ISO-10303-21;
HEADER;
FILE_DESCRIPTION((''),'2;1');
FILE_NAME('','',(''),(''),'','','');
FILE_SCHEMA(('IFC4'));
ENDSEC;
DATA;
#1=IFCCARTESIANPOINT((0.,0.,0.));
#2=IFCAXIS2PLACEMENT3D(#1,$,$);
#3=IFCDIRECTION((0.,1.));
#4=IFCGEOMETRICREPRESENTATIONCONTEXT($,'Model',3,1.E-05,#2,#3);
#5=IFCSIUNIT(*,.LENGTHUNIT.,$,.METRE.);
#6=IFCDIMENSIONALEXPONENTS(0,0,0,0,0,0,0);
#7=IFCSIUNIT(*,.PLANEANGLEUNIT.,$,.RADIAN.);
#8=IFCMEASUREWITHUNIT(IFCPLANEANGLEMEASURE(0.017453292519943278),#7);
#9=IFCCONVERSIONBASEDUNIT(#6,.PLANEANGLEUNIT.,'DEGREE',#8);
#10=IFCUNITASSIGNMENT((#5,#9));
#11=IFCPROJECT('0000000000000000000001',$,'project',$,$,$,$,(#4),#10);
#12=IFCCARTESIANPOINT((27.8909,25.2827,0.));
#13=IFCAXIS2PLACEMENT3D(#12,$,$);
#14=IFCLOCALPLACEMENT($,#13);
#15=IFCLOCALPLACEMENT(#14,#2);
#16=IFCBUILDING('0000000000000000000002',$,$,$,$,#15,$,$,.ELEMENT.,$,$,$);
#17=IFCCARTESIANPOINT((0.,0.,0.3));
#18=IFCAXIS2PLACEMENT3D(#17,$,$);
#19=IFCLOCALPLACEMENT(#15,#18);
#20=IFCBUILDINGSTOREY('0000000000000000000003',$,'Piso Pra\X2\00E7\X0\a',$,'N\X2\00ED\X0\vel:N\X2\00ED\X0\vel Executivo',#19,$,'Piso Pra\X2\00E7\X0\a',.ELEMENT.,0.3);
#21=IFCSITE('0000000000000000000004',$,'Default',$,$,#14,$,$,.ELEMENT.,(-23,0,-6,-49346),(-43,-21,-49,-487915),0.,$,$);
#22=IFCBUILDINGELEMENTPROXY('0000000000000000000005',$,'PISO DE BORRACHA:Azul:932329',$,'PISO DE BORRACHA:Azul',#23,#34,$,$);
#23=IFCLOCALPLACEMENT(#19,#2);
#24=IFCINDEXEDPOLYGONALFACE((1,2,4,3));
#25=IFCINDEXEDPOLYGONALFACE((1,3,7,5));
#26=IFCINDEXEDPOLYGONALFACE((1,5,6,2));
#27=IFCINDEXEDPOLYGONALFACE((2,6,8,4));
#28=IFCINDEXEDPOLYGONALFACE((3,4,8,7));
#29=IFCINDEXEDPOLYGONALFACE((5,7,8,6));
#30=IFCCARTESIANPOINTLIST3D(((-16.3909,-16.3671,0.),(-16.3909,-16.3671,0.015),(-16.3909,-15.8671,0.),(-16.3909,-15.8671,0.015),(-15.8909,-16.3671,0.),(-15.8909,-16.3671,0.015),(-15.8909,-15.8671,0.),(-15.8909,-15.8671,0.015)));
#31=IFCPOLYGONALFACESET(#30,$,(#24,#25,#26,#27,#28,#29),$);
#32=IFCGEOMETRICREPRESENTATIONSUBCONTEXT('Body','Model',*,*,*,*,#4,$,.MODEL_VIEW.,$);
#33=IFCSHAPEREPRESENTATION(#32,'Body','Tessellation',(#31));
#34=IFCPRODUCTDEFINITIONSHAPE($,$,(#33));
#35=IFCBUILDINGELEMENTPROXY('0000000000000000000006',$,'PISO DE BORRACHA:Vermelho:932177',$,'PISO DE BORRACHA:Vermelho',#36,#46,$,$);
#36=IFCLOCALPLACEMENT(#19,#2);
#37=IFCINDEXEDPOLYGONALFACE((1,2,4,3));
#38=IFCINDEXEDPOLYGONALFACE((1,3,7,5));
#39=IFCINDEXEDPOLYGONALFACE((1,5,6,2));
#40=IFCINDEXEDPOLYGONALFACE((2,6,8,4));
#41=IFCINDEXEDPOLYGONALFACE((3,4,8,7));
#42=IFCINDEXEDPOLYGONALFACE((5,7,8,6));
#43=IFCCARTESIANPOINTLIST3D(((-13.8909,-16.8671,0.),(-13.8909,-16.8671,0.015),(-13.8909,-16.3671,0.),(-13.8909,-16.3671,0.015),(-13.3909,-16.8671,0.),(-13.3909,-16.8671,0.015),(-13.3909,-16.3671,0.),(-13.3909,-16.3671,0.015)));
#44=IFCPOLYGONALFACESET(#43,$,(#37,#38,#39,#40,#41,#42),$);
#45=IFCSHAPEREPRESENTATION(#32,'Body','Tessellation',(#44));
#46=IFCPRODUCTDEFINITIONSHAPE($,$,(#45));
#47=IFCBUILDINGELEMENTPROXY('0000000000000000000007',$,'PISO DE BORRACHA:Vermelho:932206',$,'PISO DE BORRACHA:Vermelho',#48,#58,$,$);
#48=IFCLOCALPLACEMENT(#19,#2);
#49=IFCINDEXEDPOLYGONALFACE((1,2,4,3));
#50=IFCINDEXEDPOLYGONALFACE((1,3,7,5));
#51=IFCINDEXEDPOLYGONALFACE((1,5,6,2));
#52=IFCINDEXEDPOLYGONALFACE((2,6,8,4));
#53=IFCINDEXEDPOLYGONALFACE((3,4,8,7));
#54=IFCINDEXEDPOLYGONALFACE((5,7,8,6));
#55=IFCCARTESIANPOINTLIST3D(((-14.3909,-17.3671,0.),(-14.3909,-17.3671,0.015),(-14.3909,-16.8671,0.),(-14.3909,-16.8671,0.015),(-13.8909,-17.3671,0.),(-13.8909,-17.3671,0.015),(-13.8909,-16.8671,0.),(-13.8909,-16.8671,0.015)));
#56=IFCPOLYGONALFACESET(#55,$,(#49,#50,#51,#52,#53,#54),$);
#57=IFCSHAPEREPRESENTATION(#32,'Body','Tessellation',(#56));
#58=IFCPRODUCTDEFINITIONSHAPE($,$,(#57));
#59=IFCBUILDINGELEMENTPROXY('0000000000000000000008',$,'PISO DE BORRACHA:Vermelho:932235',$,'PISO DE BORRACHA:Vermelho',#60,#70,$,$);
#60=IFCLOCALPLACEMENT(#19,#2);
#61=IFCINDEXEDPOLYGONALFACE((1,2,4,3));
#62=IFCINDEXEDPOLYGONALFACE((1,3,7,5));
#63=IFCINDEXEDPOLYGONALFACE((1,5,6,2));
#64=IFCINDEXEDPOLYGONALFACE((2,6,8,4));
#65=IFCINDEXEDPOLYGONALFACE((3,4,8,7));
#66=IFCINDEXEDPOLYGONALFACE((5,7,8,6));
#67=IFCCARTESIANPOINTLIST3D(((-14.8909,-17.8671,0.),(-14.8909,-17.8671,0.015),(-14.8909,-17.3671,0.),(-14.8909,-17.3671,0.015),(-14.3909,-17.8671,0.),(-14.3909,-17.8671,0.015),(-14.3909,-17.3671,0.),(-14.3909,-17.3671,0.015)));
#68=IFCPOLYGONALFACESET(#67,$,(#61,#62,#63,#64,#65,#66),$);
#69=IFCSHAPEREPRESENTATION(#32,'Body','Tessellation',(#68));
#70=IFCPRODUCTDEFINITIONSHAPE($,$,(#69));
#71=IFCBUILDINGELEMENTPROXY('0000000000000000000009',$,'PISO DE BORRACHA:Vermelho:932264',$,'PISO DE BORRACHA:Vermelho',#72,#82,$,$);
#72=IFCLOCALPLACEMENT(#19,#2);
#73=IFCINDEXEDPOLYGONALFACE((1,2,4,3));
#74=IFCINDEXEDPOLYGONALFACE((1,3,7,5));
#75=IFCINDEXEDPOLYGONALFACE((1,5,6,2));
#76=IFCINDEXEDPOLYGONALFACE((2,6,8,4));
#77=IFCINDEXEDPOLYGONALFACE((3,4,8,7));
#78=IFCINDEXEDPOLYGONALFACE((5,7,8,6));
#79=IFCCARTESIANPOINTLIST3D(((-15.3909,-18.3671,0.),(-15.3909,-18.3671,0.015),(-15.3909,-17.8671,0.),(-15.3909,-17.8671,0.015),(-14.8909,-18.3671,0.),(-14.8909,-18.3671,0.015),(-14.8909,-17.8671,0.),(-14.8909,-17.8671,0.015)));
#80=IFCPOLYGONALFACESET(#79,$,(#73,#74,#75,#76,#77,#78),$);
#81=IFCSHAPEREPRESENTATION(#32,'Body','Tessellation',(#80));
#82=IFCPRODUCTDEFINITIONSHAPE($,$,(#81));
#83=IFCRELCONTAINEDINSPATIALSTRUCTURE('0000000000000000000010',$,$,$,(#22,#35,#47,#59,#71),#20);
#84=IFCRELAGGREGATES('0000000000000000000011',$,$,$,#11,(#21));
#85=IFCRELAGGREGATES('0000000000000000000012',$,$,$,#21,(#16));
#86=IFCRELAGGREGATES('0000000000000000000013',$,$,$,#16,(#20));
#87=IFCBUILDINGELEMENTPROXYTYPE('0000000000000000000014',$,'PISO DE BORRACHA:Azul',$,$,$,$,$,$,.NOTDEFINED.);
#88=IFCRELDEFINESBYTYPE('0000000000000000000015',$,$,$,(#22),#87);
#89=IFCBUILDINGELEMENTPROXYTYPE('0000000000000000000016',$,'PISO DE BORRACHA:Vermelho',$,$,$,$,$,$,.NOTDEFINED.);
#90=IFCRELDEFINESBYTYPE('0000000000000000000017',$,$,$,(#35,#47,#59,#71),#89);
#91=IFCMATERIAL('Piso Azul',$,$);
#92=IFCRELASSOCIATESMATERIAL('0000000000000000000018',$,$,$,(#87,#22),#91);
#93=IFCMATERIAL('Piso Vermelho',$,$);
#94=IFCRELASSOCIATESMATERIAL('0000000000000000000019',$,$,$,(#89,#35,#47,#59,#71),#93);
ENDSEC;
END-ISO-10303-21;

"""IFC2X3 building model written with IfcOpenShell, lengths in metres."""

from ifc_helpers import new_model, entity, si_unit, converted_unit, direction, frame, origin, origin_2d_with_axis, place, context, subcontext, project, spatial, rectangle, extrude, source, transform, mapped, material, type_object, type_shapes, element, save


model = new_model("IFC2X3")

# Units and contexts
model_context = context("Model", 3, precision=1e-05, world=origin(), true_north=direction((0.0, 1.0)))
body_context = subcontext(model_context, "Body", "Model", "MODEL_VIEW")
ifc_project = project(units=[si_unit("LENGTHUNIT", "METRE"), converted_unit("PLANEANGLEUNIT", "DEGREE", entity("IfcPlaneAngleMeasure", 0.017453292519943278), si_unit("PLANEANGLEUNIT", "RADIAN"), dimensions=[0, 0, 0, 0, 0, 0, 0])], contexts=[model_context])

# Site, building, storey
site_placement = place(None, frame((27.8909, 25.2827, 0.0)))
site = spatial("IfcSite", under=ifc_project, at=site_placement, Name="Default", CompositionType="ELEMENT", RefLatitude=(-23, 0, -6, -49346), RefLongitude=(-43, -21, -49, -487915), RefElevation=0.0)
building_placement = place(site_placement, origin())
building = spatial("IfcBuilding", under=site, at=building_placement, CompositionType="ELEMENT")
storey_placement = place(building_placement, frame((0.0, 0.0, 0.3)))
storey = spatial("IfcBuildingStorey", under=building, at=storey_placement, Name="Piso Praça", ObjectType="Nível:Nível Executivo", LongName="Piso Praça", CompositionType="ELEMENT", Elevation=0.3)

# Building element proxies
ifc_material_1 = material(Name="Piso Azul")
building_element_proxy_type_1 = type_object("IfcBuildingElementProxyType", Name="PISO DE BORRACHA:Azul", PredefinedType="NOTDEFINED", material=ifc_material_1)
shared_shape_1 = source(origin(), body_context, "Body", "SweptSolid", [
    extrude(rectangle(XDim=0.5, YDim=0.5, at=origin_2d_with_axis()), frame((0.25, 0.25, 0.0), z_axis=(0.0, 0.0, 1.0), x_axis=(-1.0, 0.0, 0.0)), (0.0, 0.0, 1.0), 0.015),
])
type_shapes(building_element_proxy_type_1, [shared_shape_1])
for number, where, z_axis, x_axis, name in (
    (1, (-16.3909, -15.8671, 0.0), (0.0, 0.0, 1.0), (0.0, -1.0, 0.0), "PISO DE BORRACHA:Azul:932329"),
):
    element("IfcBuildingElementProxy", number, at=place(storey_placement, frame(where, z_axis=z_axis, x_axis=x_axis)), inside=storey, type_object=building_element_proxy_type_1, material=ifc_material_1, Name=name, ObjectType="PISO DE BORRACHA:Azul", context=body_context, shape_type="MappedRepresentation", body=[
        mapped(shared_shape_1, transform((0.0, 0.0, 0.0), scale=1.0)),
    ])
ifc_material_2 = material(Name="Piso Vermelho")
building_element_proxy_type_2 = type_object("IfcBuildingElementProxyType", Name="PISO DE BORRACHA:Vermelho", PredefinedType="NOTDEFINED", material=ifc_material_2)
shared_shape_2 = source(origin(), body_context, "Body", "SweptSolid", [
    extrude(rectangle(XDim=0.5, YDim=0.5, at=origin_2d_with_axis()), frame((0.25, 0.25, 0.0), z_axis=(0.0, 0.0, 1.0), x_axis=(-1.0, 0.0, 0.0)), (0.0, 0.0, 1.0), 0.015),
])
type_shapes(building_element_proxy_type_2, [shared_shape_2])
for number, where, z_axis, x_axis, name in (
    (2, (-13.8909, -16.3671, 0.0), (0.0, 0.0, 1.0), (0.0, -1.0, 0.0), "PISO DE BORRACHA:Vermelho:932177"),
    (3, (-14.3909, -16.8671, 0.0), (0.0, 0.0, 1.0), (0.0, -1.0, 0.0), "PISO DE BORRACHA:Vermelho:932206"),
    (4, (-14.8909, -17.3671, 0.0), (0.0, 0.0, 1.0), (0.0, -1.0, 0.0), "PISO DE BORRACHA:Vermelho:932235"),
    (5, (-15.3909, -17.8671, 0.0), (0.0, 0.0, 1.0), (0.0, -1.0, 0.0), "PISO DE BORRACHA:Vermelho:932264"),
):
    element("IfcBuildingElementProxy", number, at=place(storey_placement, frame(where, z_axis=z_axis, x_axis=x_axis)), inside=storey, type_object=building_element_proxy_type_2, material=ifc_material_2, Name=name, ObjectType="PISO DE BORRACHA:Vermelho", context=body_context, shape_type="MappedRepresentation", body=[
        mapped(shared_shape_2, transform((0.0, 0.0, 0.0), scale=1.0)),
    ])

save(model, "model.ifc")
